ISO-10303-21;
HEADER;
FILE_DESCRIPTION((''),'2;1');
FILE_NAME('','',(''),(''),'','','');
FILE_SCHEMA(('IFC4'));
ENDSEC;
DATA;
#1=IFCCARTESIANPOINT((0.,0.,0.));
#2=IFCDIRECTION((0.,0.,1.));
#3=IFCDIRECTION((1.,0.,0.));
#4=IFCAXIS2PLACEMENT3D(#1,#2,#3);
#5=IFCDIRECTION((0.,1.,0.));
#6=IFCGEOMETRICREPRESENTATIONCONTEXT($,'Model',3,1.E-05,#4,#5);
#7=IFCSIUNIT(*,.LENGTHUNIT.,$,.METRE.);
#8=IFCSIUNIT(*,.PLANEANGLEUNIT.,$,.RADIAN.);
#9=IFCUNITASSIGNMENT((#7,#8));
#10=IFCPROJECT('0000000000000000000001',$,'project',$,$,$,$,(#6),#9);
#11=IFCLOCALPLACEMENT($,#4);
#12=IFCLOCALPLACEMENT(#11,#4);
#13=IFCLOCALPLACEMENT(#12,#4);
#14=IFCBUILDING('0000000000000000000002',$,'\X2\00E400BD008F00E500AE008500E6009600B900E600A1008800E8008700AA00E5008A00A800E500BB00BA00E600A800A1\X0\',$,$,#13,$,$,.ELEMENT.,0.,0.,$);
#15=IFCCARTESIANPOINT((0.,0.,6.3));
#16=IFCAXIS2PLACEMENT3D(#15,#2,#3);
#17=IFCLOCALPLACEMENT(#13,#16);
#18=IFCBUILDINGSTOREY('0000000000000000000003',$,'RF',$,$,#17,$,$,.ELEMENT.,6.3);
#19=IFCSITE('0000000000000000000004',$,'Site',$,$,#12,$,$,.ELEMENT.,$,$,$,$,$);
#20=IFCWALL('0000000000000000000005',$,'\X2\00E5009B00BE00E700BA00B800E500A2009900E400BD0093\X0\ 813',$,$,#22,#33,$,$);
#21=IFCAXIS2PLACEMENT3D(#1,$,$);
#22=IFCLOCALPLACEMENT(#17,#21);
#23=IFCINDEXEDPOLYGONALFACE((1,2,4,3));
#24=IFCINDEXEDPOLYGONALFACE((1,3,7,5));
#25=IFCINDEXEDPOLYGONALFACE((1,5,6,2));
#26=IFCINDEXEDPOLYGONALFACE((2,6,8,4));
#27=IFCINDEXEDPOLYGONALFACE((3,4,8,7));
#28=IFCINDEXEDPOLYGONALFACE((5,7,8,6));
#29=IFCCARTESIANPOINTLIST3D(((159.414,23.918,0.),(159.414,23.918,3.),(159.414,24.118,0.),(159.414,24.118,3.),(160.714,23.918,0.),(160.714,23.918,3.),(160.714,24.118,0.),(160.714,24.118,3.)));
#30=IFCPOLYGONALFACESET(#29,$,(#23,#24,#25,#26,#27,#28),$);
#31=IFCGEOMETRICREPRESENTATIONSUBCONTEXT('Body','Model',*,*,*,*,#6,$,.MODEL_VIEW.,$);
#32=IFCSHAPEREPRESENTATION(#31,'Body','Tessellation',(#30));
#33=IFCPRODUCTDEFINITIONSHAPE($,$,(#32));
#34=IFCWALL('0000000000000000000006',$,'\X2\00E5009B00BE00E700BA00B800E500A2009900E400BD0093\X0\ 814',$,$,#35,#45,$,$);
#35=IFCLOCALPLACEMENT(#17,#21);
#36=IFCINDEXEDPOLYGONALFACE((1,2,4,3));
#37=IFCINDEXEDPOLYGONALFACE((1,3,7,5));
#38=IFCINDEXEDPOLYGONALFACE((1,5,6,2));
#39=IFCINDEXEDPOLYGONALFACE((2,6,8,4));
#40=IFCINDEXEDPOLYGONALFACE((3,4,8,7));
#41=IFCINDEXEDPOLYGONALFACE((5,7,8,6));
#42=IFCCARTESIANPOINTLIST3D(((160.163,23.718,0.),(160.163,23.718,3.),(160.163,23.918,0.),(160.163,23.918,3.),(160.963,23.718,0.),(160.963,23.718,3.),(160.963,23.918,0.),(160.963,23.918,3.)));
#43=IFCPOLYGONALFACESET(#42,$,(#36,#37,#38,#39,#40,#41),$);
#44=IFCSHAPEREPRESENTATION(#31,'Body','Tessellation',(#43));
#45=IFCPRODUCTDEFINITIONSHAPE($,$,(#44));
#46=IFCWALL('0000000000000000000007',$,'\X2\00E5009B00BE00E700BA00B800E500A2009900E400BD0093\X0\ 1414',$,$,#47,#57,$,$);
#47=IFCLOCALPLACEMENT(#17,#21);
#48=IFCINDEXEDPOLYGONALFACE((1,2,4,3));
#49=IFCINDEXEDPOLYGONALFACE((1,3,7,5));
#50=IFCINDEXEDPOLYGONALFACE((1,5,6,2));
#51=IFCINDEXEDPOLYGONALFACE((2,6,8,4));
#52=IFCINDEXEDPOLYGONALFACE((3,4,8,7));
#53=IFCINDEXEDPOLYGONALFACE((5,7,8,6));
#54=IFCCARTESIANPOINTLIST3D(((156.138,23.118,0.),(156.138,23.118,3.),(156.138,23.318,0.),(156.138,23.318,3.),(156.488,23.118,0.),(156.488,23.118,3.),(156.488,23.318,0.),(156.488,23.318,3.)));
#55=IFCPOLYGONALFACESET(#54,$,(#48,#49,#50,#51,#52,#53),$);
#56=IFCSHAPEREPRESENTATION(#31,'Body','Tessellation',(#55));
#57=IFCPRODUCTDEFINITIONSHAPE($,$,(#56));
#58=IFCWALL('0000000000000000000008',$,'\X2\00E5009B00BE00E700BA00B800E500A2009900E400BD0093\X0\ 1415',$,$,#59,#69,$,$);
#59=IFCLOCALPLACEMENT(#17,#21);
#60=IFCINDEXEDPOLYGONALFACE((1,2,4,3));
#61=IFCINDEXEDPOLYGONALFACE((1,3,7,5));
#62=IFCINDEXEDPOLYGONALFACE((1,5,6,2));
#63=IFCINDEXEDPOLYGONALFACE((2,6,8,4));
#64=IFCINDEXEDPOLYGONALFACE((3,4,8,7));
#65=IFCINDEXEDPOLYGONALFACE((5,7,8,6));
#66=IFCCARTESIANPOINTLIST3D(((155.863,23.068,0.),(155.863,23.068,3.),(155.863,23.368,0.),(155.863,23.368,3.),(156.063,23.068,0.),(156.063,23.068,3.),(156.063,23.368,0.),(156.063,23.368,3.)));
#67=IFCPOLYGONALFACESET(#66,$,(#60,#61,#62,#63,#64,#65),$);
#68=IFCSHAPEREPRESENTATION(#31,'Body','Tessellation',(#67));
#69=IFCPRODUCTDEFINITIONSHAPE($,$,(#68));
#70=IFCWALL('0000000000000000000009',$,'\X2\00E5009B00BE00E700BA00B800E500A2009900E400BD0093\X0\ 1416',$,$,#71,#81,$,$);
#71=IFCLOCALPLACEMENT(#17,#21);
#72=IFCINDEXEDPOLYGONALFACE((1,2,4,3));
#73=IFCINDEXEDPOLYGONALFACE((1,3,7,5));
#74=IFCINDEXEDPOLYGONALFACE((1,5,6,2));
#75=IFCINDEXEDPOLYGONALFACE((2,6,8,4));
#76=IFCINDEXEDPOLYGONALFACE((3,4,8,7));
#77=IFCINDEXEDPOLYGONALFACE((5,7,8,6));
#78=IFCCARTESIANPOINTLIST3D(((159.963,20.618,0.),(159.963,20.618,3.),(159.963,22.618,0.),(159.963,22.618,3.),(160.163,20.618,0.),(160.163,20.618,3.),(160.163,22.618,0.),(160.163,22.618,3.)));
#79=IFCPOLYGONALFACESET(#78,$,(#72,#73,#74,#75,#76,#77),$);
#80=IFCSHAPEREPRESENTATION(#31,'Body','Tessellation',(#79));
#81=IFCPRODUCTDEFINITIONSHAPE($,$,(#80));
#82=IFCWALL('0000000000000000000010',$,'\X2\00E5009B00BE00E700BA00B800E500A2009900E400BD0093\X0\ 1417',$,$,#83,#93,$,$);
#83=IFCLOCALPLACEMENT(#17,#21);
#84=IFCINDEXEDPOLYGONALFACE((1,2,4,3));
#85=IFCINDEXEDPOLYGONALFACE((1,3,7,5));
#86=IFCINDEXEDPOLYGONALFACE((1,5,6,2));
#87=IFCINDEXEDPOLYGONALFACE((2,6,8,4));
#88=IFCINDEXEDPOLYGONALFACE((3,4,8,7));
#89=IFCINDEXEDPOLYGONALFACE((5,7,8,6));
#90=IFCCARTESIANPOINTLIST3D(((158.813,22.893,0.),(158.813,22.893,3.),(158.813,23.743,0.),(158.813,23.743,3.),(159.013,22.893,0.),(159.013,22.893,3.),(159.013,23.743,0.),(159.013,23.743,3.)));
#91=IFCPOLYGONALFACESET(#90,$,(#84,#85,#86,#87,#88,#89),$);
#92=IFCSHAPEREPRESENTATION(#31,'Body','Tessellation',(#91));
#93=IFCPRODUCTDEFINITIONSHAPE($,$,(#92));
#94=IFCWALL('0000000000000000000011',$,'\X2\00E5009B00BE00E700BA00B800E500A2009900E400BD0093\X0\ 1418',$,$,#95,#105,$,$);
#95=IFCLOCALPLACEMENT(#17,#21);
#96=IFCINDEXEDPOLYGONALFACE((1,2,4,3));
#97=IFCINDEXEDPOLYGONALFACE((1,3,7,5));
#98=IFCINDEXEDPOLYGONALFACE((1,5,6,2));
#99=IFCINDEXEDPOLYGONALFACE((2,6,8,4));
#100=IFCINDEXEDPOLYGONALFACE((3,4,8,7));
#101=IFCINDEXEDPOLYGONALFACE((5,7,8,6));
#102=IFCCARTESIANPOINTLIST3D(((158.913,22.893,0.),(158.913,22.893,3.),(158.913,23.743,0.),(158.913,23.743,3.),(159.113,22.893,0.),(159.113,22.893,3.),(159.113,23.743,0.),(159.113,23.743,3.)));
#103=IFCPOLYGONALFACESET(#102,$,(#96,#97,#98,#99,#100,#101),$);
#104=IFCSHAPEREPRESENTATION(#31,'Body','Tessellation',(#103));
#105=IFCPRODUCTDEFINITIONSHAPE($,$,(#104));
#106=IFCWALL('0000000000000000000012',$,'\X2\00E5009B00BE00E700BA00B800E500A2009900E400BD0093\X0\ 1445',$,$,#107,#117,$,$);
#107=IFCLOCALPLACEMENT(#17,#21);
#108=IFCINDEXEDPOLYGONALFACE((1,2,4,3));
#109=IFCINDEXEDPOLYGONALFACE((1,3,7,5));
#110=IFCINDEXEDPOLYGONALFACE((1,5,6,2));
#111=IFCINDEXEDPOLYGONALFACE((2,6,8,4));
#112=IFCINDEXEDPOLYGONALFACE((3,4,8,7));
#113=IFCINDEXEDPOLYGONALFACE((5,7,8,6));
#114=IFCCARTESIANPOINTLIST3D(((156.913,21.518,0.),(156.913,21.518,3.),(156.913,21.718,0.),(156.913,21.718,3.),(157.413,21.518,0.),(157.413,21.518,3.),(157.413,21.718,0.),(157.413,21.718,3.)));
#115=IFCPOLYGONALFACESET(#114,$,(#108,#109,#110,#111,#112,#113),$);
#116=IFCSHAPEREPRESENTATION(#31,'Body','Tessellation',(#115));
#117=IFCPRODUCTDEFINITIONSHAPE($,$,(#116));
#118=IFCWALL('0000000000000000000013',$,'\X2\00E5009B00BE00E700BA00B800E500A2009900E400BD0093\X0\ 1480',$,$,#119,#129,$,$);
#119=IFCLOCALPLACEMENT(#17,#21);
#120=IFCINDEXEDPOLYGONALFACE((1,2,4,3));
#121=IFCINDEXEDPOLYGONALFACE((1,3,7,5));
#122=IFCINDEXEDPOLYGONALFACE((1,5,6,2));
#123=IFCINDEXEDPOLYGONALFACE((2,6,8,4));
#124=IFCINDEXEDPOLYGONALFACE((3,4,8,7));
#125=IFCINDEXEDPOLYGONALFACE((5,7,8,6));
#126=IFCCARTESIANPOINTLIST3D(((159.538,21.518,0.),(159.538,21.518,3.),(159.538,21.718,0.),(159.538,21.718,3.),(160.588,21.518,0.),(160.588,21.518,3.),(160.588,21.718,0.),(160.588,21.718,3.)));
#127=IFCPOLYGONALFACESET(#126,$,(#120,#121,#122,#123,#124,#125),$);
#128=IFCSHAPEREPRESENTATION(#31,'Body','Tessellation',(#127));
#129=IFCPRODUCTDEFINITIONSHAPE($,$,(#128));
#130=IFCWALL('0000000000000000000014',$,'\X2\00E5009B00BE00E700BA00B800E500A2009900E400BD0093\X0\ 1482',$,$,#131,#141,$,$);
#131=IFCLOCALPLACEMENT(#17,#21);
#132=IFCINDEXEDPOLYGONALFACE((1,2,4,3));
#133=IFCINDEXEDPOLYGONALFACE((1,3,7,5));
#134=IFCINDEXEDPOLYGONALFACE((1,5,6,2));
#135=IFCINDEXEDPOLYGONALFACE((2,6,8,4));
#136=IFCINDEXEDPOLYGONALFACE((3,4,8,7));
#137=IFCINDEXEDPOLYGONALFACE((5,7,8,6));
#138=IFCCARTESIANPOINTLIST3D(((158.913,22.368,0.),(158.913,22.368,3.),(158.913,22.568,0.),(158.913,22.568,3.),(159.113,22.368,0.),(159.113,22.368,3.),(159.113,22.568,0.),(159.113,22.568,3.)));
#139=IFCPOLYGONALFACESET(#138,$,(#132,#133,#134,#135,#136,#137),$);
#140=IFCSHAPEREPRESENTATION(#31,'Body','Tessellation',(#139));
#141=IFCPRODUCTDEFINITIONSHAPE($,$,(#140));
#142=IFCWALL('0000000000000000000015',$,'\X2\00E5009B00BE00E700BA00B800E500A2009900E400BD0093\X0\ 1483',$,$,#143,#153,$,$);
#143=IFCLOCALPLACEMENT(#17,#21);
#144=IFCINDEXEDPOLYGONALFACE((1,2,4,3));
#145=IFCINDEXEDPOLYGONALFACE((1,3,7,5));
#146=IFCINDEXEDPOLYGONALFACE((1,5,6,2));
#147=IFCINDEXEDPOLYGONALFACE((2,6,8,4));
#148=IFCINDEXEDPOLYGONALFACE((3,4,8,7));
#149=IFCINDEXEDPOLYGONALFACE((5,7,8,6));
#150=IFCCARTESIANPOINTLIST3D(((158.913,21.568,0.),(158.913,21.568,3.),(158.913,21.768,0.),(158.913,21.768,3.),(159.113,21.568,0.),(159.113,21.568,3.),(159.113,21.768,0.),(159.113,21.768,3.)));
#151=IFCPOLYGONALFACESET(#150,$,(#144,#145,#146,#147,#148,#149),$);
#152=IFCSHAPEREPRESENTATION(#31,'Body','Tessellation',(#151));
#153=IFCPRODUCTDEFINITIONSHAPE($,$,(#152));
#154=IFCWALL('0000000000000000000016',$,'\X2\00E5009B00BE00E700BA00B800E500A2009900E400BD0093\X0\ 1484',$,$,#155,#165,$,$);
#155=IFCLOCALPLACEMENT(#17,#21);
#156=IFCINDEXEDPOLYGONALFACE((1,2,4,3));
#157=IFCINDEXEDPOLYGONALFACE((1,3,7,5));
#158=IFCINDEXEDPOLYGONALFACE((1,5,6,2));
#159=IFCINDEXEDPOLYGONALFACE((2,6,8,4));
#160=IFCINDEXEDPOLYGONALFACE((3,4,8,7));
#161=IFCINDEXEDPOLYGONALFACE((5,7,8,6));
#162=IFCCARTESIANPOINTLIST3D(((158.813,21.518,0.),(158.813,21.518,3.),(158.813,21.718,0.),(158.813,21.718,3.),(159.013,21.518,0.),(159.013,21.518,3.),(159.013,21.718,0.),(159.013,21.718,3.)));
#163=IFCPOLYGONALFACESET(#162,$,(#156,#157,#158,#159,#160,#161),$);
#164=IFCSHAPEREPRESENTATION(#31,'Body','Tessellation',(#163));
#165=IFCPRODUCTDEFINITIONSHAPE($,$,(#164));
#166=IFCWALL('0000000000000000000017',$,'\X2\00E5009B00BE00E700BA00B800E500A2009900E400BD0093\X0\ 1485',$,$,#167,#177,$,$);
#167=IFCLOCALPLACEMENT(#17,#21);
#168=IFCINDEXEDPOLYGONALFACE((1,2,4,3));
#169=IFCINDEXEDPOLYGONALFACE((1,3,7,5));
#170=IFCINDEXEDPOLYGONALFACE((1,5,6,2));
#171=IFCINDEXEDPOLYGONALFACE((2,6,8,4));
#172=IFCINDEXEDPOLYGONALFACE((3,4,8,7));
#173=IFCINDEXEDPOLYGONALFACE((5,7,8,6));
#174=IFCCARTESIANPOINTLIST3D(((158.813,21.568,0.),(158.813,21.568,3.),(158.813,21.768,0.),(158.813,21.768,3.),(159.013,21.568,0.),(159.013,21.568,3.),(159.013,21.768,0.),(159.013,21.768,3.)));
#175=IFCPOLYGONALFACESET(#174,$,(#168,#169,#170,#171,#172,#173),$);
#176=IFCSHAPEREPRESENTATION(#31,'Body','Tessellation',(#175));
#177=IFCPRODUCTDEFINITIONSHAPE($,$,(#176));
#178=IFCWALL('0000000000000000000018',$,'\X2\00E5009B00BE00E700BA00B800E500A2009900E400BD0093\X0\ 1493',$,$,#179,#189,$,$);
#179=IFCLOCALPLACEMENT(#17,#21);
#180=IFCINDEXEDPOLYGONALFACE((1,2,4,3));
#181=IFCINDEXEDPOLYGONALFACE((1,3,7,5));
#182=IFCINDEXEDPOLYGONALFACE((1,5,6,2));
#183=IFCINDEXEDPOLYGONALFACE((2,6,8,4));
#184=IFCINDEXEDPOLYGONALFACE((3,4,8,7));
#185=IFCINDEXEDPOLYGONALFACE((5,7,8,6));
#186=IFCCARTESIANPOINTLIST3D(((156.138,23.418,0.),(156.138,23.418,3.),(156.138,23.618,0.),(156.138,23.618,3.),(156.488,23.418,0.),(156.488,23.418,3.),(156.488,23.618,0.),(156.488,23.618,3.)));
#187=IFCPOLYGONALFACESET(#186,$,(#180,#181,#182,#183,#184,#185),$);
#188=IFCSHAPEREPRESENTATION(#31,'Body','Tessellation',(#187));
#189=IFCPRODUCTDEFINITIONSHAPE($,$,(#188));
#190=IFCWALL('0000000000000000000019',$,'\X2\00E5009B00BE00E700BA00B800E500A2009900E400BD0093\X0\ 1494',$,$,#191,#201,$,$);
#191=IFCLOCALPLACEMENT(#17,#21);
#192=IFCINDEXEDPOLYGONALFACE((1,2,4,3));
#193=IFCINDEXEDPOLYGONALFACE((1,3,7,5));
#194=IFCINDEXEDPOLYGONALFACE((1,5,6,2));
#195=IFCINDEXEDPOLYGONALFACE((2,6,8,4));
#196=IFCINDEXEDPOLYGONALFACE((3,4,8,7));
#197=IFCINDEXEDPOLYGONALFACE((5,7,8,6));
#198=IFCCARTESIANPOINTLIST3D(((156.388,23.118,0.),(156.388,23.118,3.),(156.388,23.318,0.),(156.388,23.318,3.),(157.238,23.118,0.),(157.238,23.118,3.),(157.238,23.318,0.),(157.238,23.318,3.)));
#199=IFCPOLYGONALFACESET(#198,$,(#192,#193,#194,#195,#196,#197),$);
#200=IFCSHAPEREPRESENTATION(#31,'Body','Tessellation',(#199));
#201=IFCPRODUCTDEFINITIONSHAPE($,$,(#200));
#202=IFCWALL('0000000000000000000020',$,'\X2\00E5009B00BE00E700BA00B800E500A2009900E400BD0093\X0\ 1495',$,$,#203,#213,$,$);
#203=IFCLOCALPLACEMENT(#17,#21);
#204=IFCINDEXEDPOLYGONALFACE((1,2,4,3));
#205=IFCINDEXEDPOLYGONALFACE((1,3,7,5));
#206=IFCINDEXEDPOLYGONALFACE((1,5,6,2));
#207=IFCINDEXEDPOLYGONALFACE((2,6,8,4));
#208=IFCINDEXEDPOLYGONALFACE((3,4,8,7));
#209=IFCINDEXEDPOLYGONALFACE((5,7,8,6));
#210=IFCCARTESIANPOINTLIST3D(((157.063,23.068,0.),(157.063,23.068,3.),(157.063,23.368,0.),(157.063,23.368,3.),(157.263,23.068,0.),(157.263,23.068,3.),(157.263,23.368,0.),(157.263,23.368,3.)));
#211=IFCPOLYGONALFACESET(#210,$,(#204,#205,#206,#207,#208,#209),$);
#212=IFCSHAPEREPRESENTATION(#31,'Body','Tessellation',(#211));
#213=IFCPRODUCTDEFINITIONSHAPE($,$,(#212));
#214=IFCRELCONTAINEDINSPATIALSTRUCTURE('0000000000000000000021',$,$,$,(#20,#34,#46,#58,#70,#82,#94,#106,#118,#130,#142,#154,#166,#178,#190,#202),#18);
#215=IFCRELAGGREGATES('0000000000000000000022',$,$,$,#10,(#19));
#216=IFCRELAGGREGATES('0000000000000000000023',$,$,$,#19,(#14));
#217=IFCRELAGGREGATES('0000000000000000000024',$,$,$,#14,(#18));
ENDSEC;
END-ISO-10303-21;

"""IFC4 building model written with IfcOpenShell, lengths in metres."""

from ifc_helpers import new_model, si_unit, direction, frame, frame_2d, origin_with_axes, place, context, subcontext, project, spatial, rectangle, extrude, element, save


model = new_model("IFC4")

# Units and contexts
model_context = context("Model", 3, precision=1e-05, world=origin_with_axes(), true_north=direction((0.0, 1.0, 0.0)))
body_context = subcontext(model_context, "Body", "Model", "MODEL_VIEW")
ifc_project = project(units=[si_unit("LENGTHUNIT", "METRE"), si_unit("PLANEANGLEUNIT", "RADIAN")], contexts=[model_context])

# Site, building, storey
placement = place(None, origin_with_axes())
site_placement = place(placement, origin_with_axes())
site = spatial("IfcSite", under=ifc_project, at=site_placement, Name="Site", CompositionType="ELEMENT")
building_placement = place(site_placement, origin_with_axes())
building = spatial("IfcBuilding", under=site, at=building_placement, Name="ä½\u008få®\u0085æ\u0096¹æ¡\u0088è\u0087ªå\u008a¨å»ºæ¨¡", CompositionType="ELEMENT", ElevationOfRefHeight=0.0, ElevationOfTerrain=0.0)
storey_placement = place(building_placement, frame((0.0, 0.0, 6.3), z_axis=(0.0, 0.0, 1.0), x_axis=(1.0, 0.0, 0.0)))
storey = spatial("IfcBuildingStorey", under=building, at=storey_placement, Name="RF", CompositionType="ELEMENT", Elevation=6.3)

# Walls
wall_1_placement = place(storey_placement, frame((160.064, 24.018, 0.0), z_axis=(0.0, 0.0, 1.0), x_axis=(1.0, 0.0, 0.0)))
element("IfcWall", 1, at=wall_1_placement, inside=storey, Name="å\u009b¾çº¸å¢\u0099ä½\u0093 813", context=body_context, shape_type="SweptSolid", body=[
    extrude(rectangle(XDim=1.3, YDim=0.2, at=frame_2d((0.0, 0.0), x_axis=(1.0, 0.0, 0.0))), frame((0.0, 0.0, 0.0), z_axis=(0.0, 0.0, 1.0)), (0.0, 0.0, 1.0), 3.0),
])
wall_2_placement = place(storey_placement, frame((160.563, 23.818, 0.0), z_axis=(0.0, 0.0, 1.0), x_axis=(1.0, 0.0, 0.0)))
element("IfcWall", 2, at=wall_2_placement, inside=storey, Name="å\u009b¾çº¸å¢\u0099ä½\u0093 814", context=body_context, shape_type="SweptSolid", body=[
    extrude(rectangle(XDim=0.8, YDim=0.2, at=frame_2d((0.0, 0.0), x_axis=(1.0, 0.0, 0.0))), frame((0.0, 0.0, 0.0), z_axis=(0.0, 0.0, 1.0)), (0.0, 0.0, 1.0), 3.0),
])
wall_3_placement = place(storey_placement, frame((156.313, 23.218, 0.0), z_axis=(0.0, 0.0, 1.0), x_axis=(-1.0, 0.0, 0.0)))
element("IfcWall", 3, at=wall_3_placement, inside=storey, Name="å\u009b¾çº¸å¢\u0099ä½\u0093 1414", context=body_context, shape_type="SweptSolid", body=[
    extrude(rectangle(XDim=0.35, YDim=0.2, at=frame_2d((0.0, 0.0), x_axis=(1.0, 0.0, 0.0))), frame((0.0, 0.0, 0.0), z_axis=(0.0, 0.0, 1.0)), (0.0, 0.0, 1.0), 3.0),
])
wall_4_placement = place(storey_placement, frame((155.963, 23.218, 0.0), z_axis=(0.0, 0.0, 1.0), x_axis=(0.0, 1.0, 0.0)))
element("IfcWall", 4, at=wall_4_placement, inside=storey, Name="å\u009b¾çº¸å¢\u0099ä½\u0093 1415", context=body_context, shape_type="SweptSolid", body=[
    extrude(rectangle(XDim=0.3, YDim=0.2, at=frame_2d((0.0, 0.0), x_axis=(1.0, 0.0, 0.0))), frame((0.0, 0.0, 0.0), z_axis=(0.0, 0.0, 1.0)), (0.0, 0.0, 1.0), 3.0),
])
wall_5_placement = place(storey_placement, frame((160.063, 21.618, 0.0), z_axis=(0.0, 0.0, 1.0), x_axis=(0.0, 1.0, 0.0)))
element("IfcWall", 5, at=wall_5_placement, inside=storey, Name="å\u009b¾çº¸å¢\u0099ä½\u0093 1416", context=body_context, shape_type="SweptSolid", body=[
    extrude(rectangle(XDim=2.0, YDim=0.2, at=frame_2d((0.0, 0.0), x_axis=(1.0, 0.0, 0.0))), frame((0.0, 0.0, 0.0), z_axis=(0.0, 0.0, 1.0)), (0.0, 0.0, 1.0), 3.0),
])
for number, where, z_axis, x_axis, name in (
    (6, (158.913, 23.318, 0.0), (0.0, 0.0, 1.0), (0.0, -1.0, 0.0), "å\u009b¾çº¸å¢\u0099ä½\u0093 1417"),
    (7, (159.013, 23.318, 0.0), (0.0, 0.0, 1.0), (0.0, -1.0, 0.0), "å\u009b¾çº¸å¢\u0099ä½\u0093 1418"),
):
    element("IfcWall", number, at=place(storey_placement, frame(where, z_axis=z_axis, x_axis=x_axis)), inside=storey, Name=name, context=body_context, shape_type="SweptSolid", body=[
        extrude(rectangle(XDim=0.85, YDim=0.2, at=frame_2d((0.0, 0.0), x_axis=(1.0, 0.0, 0.0))), frame((0.0, 0.0, 0.0), z_axis=(0.0, 0.0, 1.0)), (0.0, 0.0, 1.0), 3.0),
    ])
wall_6_placement = place(storey_placement, frame((157.163, 21.618, 0.0), z_axis=(0.0, 0.0, 1.0), x_axis=(-1.0, 0.0, 0.0)))
element("IfcWall", 8, at=wall_6_placement, inside=storey, Name="å\u009b¾çº¸å¢\u0099ä½\u0093 1445", context=body_context, shape_type="SweptSolid", body=[
    extrude(rectangle(XDim=0.5, YDim=0.2, at=frame_2d((0.0, 0.0), x_axis=(1.0, 0.0, 0.0))), frame((0.0, 0.0, 0.0), z_axis=(0.0, 0.0, 1.0)), (0.0, 0.0, 1.0), 3.0),
])
wall_7_placement = place(storey_placement, frame((160.063, 21.618, 0.0), z_axis=(0.0, 0.0, 1.0), x_axis=(-1.0, 0.0, 0.0)))
element("IfcWall", 9, at=wall_7_placement, inside=storey, Name="å\u009b¾çº¸å¢\u0099ä½\u0093 1480", context=body_context, shape_type="SweptSolid", body=[
    extrude(rectangle(XDim=1.05, YDim=0.2, at=frame_2d((0.0, 0.0), x_axis=(1.0, 0.0, 0.0))), frame((0.0, 0.0, 0.0), z_axis=(0.0, 0.0, 1.0)), (0.0, 0.0, 1.0), 3.0),
])
for number, where, z_axis, x_axis, name in (
    (10, (159.013, 22.468, 0.0), (0.0, 0.0, 1.0), (-1.0, 0.0, 0.0), "å\u009b¾çº¸å¢\u0099ä½\u0093 1482"),
    (11, (159.013, 21.668, 0.0), (0.0, 0.0, 1.0), (-1.0, 0.0, 0.0), "å\u009b¾çº¸å¢\u0099ä½\u0093 1483"),
    (12, (158.913, 21.618, 0.0), (0.0, 0.0, 1.0), (0.0, -1.0, 0.0), "å\u009b¾çº¸å¢\u0099ä½\u0093 1484"),
    (13, (158.913, 21.668, 0.0), (0.0, 0.0, 1.0), (0.0, -1.0, 0.0), "å\u009b¾çº¸å¢\u0099ä½\u0093 1485"),
):
    element("IfcWall", number, at=place(storey_placement, frame(where, z_axis=z_axis, x_axis=x_axis)), inside=storey, Name=name, context=body_context, shape_type="SweptSolid", body=[
        extrude(rectangle(XDim=0.2, YDim=0.2, at=frame_2d((0.0, 0.0), x_axis=(1.0, 0.0, 0.0))), frame((0.0, 0.0, 0.0), z_axis=(0.0, 0.0, 1.0)), (0.0, 0.0, 1.0), 3.0),
    ])
wall_8_placement = place(storey_placement, frame((156.313, 23.518, 0.0), z_axis=(0.0, 0.0, 1.0), x_axis=(-1.0, 0.0, 0.0)))
element("IfcWall", 14, at=wall_8_placement, inside=storey, Name="å\u009b¾çº¸å¢\u0099ä½\u0093 1493", context=body_context, shape_type="SweptSolid", body=[
    extrude(rectangle(XDim=0.35, YDim=0.2, at=frame_2d((0.0, 0.0), x_axis=(1.0, 0.0, 0.0))), frame((0.0, 0.0, 0.0), z_axis=(0.0, 0.0, 1.0)), (0.0, 0.0, 1.0), 3.0),
])
wall_9_placement = place(storey_placement, frame((156.813, 23.218, 0.0), z_axis=(0.0, 0.0, 1.0), x_axis=(-1.0, 0.0, 0.0)))
element("IfcWall", 15, at=wall_9_placement, inside=storey, Name="å\u009b¾çº¸å¢\u0099ä½\u0093 1494", context=body_context, shape_type="SweptSolid", body=[
    extrude(rectangle(XDim=0.85, YDim=0.2, at=frame_2d((0.0, 0.0), x_axis=(1.0, 0.0, 0.0))), frame((0.0, 0.0, 0.0), z_axis=(0.0, 0.0, 1.0)), (0.0, 0.0, 1.0), 3.0),
])
wall_10_placement = place(storey_placement, frame((157.163, 23.218, 0.0), z_axis=(0.0, 0.0, 1.0), x_axis=(0.0, 1.0, 0.0)))
element("IfcWall", 16, at=wall_10_placement, inside=storey, Name="å\u009b¾çº¸å¢\u0099ä½\u0093 1495", context=body_context, shape_type="SweptSolid", body=[
    extrude(rectangle(XDim=0.3, YDim=0.2, at=frame_2d((0.0, 0.0), x_axis=(1.0, 0.0, 0.0))), frame((0.0, 0.0, 0.0), z_axis=(0.0, 0.0, 1.0)), (0.0, 0.0, 1.0), 3.0),
])

save(model, "model.ifc")
